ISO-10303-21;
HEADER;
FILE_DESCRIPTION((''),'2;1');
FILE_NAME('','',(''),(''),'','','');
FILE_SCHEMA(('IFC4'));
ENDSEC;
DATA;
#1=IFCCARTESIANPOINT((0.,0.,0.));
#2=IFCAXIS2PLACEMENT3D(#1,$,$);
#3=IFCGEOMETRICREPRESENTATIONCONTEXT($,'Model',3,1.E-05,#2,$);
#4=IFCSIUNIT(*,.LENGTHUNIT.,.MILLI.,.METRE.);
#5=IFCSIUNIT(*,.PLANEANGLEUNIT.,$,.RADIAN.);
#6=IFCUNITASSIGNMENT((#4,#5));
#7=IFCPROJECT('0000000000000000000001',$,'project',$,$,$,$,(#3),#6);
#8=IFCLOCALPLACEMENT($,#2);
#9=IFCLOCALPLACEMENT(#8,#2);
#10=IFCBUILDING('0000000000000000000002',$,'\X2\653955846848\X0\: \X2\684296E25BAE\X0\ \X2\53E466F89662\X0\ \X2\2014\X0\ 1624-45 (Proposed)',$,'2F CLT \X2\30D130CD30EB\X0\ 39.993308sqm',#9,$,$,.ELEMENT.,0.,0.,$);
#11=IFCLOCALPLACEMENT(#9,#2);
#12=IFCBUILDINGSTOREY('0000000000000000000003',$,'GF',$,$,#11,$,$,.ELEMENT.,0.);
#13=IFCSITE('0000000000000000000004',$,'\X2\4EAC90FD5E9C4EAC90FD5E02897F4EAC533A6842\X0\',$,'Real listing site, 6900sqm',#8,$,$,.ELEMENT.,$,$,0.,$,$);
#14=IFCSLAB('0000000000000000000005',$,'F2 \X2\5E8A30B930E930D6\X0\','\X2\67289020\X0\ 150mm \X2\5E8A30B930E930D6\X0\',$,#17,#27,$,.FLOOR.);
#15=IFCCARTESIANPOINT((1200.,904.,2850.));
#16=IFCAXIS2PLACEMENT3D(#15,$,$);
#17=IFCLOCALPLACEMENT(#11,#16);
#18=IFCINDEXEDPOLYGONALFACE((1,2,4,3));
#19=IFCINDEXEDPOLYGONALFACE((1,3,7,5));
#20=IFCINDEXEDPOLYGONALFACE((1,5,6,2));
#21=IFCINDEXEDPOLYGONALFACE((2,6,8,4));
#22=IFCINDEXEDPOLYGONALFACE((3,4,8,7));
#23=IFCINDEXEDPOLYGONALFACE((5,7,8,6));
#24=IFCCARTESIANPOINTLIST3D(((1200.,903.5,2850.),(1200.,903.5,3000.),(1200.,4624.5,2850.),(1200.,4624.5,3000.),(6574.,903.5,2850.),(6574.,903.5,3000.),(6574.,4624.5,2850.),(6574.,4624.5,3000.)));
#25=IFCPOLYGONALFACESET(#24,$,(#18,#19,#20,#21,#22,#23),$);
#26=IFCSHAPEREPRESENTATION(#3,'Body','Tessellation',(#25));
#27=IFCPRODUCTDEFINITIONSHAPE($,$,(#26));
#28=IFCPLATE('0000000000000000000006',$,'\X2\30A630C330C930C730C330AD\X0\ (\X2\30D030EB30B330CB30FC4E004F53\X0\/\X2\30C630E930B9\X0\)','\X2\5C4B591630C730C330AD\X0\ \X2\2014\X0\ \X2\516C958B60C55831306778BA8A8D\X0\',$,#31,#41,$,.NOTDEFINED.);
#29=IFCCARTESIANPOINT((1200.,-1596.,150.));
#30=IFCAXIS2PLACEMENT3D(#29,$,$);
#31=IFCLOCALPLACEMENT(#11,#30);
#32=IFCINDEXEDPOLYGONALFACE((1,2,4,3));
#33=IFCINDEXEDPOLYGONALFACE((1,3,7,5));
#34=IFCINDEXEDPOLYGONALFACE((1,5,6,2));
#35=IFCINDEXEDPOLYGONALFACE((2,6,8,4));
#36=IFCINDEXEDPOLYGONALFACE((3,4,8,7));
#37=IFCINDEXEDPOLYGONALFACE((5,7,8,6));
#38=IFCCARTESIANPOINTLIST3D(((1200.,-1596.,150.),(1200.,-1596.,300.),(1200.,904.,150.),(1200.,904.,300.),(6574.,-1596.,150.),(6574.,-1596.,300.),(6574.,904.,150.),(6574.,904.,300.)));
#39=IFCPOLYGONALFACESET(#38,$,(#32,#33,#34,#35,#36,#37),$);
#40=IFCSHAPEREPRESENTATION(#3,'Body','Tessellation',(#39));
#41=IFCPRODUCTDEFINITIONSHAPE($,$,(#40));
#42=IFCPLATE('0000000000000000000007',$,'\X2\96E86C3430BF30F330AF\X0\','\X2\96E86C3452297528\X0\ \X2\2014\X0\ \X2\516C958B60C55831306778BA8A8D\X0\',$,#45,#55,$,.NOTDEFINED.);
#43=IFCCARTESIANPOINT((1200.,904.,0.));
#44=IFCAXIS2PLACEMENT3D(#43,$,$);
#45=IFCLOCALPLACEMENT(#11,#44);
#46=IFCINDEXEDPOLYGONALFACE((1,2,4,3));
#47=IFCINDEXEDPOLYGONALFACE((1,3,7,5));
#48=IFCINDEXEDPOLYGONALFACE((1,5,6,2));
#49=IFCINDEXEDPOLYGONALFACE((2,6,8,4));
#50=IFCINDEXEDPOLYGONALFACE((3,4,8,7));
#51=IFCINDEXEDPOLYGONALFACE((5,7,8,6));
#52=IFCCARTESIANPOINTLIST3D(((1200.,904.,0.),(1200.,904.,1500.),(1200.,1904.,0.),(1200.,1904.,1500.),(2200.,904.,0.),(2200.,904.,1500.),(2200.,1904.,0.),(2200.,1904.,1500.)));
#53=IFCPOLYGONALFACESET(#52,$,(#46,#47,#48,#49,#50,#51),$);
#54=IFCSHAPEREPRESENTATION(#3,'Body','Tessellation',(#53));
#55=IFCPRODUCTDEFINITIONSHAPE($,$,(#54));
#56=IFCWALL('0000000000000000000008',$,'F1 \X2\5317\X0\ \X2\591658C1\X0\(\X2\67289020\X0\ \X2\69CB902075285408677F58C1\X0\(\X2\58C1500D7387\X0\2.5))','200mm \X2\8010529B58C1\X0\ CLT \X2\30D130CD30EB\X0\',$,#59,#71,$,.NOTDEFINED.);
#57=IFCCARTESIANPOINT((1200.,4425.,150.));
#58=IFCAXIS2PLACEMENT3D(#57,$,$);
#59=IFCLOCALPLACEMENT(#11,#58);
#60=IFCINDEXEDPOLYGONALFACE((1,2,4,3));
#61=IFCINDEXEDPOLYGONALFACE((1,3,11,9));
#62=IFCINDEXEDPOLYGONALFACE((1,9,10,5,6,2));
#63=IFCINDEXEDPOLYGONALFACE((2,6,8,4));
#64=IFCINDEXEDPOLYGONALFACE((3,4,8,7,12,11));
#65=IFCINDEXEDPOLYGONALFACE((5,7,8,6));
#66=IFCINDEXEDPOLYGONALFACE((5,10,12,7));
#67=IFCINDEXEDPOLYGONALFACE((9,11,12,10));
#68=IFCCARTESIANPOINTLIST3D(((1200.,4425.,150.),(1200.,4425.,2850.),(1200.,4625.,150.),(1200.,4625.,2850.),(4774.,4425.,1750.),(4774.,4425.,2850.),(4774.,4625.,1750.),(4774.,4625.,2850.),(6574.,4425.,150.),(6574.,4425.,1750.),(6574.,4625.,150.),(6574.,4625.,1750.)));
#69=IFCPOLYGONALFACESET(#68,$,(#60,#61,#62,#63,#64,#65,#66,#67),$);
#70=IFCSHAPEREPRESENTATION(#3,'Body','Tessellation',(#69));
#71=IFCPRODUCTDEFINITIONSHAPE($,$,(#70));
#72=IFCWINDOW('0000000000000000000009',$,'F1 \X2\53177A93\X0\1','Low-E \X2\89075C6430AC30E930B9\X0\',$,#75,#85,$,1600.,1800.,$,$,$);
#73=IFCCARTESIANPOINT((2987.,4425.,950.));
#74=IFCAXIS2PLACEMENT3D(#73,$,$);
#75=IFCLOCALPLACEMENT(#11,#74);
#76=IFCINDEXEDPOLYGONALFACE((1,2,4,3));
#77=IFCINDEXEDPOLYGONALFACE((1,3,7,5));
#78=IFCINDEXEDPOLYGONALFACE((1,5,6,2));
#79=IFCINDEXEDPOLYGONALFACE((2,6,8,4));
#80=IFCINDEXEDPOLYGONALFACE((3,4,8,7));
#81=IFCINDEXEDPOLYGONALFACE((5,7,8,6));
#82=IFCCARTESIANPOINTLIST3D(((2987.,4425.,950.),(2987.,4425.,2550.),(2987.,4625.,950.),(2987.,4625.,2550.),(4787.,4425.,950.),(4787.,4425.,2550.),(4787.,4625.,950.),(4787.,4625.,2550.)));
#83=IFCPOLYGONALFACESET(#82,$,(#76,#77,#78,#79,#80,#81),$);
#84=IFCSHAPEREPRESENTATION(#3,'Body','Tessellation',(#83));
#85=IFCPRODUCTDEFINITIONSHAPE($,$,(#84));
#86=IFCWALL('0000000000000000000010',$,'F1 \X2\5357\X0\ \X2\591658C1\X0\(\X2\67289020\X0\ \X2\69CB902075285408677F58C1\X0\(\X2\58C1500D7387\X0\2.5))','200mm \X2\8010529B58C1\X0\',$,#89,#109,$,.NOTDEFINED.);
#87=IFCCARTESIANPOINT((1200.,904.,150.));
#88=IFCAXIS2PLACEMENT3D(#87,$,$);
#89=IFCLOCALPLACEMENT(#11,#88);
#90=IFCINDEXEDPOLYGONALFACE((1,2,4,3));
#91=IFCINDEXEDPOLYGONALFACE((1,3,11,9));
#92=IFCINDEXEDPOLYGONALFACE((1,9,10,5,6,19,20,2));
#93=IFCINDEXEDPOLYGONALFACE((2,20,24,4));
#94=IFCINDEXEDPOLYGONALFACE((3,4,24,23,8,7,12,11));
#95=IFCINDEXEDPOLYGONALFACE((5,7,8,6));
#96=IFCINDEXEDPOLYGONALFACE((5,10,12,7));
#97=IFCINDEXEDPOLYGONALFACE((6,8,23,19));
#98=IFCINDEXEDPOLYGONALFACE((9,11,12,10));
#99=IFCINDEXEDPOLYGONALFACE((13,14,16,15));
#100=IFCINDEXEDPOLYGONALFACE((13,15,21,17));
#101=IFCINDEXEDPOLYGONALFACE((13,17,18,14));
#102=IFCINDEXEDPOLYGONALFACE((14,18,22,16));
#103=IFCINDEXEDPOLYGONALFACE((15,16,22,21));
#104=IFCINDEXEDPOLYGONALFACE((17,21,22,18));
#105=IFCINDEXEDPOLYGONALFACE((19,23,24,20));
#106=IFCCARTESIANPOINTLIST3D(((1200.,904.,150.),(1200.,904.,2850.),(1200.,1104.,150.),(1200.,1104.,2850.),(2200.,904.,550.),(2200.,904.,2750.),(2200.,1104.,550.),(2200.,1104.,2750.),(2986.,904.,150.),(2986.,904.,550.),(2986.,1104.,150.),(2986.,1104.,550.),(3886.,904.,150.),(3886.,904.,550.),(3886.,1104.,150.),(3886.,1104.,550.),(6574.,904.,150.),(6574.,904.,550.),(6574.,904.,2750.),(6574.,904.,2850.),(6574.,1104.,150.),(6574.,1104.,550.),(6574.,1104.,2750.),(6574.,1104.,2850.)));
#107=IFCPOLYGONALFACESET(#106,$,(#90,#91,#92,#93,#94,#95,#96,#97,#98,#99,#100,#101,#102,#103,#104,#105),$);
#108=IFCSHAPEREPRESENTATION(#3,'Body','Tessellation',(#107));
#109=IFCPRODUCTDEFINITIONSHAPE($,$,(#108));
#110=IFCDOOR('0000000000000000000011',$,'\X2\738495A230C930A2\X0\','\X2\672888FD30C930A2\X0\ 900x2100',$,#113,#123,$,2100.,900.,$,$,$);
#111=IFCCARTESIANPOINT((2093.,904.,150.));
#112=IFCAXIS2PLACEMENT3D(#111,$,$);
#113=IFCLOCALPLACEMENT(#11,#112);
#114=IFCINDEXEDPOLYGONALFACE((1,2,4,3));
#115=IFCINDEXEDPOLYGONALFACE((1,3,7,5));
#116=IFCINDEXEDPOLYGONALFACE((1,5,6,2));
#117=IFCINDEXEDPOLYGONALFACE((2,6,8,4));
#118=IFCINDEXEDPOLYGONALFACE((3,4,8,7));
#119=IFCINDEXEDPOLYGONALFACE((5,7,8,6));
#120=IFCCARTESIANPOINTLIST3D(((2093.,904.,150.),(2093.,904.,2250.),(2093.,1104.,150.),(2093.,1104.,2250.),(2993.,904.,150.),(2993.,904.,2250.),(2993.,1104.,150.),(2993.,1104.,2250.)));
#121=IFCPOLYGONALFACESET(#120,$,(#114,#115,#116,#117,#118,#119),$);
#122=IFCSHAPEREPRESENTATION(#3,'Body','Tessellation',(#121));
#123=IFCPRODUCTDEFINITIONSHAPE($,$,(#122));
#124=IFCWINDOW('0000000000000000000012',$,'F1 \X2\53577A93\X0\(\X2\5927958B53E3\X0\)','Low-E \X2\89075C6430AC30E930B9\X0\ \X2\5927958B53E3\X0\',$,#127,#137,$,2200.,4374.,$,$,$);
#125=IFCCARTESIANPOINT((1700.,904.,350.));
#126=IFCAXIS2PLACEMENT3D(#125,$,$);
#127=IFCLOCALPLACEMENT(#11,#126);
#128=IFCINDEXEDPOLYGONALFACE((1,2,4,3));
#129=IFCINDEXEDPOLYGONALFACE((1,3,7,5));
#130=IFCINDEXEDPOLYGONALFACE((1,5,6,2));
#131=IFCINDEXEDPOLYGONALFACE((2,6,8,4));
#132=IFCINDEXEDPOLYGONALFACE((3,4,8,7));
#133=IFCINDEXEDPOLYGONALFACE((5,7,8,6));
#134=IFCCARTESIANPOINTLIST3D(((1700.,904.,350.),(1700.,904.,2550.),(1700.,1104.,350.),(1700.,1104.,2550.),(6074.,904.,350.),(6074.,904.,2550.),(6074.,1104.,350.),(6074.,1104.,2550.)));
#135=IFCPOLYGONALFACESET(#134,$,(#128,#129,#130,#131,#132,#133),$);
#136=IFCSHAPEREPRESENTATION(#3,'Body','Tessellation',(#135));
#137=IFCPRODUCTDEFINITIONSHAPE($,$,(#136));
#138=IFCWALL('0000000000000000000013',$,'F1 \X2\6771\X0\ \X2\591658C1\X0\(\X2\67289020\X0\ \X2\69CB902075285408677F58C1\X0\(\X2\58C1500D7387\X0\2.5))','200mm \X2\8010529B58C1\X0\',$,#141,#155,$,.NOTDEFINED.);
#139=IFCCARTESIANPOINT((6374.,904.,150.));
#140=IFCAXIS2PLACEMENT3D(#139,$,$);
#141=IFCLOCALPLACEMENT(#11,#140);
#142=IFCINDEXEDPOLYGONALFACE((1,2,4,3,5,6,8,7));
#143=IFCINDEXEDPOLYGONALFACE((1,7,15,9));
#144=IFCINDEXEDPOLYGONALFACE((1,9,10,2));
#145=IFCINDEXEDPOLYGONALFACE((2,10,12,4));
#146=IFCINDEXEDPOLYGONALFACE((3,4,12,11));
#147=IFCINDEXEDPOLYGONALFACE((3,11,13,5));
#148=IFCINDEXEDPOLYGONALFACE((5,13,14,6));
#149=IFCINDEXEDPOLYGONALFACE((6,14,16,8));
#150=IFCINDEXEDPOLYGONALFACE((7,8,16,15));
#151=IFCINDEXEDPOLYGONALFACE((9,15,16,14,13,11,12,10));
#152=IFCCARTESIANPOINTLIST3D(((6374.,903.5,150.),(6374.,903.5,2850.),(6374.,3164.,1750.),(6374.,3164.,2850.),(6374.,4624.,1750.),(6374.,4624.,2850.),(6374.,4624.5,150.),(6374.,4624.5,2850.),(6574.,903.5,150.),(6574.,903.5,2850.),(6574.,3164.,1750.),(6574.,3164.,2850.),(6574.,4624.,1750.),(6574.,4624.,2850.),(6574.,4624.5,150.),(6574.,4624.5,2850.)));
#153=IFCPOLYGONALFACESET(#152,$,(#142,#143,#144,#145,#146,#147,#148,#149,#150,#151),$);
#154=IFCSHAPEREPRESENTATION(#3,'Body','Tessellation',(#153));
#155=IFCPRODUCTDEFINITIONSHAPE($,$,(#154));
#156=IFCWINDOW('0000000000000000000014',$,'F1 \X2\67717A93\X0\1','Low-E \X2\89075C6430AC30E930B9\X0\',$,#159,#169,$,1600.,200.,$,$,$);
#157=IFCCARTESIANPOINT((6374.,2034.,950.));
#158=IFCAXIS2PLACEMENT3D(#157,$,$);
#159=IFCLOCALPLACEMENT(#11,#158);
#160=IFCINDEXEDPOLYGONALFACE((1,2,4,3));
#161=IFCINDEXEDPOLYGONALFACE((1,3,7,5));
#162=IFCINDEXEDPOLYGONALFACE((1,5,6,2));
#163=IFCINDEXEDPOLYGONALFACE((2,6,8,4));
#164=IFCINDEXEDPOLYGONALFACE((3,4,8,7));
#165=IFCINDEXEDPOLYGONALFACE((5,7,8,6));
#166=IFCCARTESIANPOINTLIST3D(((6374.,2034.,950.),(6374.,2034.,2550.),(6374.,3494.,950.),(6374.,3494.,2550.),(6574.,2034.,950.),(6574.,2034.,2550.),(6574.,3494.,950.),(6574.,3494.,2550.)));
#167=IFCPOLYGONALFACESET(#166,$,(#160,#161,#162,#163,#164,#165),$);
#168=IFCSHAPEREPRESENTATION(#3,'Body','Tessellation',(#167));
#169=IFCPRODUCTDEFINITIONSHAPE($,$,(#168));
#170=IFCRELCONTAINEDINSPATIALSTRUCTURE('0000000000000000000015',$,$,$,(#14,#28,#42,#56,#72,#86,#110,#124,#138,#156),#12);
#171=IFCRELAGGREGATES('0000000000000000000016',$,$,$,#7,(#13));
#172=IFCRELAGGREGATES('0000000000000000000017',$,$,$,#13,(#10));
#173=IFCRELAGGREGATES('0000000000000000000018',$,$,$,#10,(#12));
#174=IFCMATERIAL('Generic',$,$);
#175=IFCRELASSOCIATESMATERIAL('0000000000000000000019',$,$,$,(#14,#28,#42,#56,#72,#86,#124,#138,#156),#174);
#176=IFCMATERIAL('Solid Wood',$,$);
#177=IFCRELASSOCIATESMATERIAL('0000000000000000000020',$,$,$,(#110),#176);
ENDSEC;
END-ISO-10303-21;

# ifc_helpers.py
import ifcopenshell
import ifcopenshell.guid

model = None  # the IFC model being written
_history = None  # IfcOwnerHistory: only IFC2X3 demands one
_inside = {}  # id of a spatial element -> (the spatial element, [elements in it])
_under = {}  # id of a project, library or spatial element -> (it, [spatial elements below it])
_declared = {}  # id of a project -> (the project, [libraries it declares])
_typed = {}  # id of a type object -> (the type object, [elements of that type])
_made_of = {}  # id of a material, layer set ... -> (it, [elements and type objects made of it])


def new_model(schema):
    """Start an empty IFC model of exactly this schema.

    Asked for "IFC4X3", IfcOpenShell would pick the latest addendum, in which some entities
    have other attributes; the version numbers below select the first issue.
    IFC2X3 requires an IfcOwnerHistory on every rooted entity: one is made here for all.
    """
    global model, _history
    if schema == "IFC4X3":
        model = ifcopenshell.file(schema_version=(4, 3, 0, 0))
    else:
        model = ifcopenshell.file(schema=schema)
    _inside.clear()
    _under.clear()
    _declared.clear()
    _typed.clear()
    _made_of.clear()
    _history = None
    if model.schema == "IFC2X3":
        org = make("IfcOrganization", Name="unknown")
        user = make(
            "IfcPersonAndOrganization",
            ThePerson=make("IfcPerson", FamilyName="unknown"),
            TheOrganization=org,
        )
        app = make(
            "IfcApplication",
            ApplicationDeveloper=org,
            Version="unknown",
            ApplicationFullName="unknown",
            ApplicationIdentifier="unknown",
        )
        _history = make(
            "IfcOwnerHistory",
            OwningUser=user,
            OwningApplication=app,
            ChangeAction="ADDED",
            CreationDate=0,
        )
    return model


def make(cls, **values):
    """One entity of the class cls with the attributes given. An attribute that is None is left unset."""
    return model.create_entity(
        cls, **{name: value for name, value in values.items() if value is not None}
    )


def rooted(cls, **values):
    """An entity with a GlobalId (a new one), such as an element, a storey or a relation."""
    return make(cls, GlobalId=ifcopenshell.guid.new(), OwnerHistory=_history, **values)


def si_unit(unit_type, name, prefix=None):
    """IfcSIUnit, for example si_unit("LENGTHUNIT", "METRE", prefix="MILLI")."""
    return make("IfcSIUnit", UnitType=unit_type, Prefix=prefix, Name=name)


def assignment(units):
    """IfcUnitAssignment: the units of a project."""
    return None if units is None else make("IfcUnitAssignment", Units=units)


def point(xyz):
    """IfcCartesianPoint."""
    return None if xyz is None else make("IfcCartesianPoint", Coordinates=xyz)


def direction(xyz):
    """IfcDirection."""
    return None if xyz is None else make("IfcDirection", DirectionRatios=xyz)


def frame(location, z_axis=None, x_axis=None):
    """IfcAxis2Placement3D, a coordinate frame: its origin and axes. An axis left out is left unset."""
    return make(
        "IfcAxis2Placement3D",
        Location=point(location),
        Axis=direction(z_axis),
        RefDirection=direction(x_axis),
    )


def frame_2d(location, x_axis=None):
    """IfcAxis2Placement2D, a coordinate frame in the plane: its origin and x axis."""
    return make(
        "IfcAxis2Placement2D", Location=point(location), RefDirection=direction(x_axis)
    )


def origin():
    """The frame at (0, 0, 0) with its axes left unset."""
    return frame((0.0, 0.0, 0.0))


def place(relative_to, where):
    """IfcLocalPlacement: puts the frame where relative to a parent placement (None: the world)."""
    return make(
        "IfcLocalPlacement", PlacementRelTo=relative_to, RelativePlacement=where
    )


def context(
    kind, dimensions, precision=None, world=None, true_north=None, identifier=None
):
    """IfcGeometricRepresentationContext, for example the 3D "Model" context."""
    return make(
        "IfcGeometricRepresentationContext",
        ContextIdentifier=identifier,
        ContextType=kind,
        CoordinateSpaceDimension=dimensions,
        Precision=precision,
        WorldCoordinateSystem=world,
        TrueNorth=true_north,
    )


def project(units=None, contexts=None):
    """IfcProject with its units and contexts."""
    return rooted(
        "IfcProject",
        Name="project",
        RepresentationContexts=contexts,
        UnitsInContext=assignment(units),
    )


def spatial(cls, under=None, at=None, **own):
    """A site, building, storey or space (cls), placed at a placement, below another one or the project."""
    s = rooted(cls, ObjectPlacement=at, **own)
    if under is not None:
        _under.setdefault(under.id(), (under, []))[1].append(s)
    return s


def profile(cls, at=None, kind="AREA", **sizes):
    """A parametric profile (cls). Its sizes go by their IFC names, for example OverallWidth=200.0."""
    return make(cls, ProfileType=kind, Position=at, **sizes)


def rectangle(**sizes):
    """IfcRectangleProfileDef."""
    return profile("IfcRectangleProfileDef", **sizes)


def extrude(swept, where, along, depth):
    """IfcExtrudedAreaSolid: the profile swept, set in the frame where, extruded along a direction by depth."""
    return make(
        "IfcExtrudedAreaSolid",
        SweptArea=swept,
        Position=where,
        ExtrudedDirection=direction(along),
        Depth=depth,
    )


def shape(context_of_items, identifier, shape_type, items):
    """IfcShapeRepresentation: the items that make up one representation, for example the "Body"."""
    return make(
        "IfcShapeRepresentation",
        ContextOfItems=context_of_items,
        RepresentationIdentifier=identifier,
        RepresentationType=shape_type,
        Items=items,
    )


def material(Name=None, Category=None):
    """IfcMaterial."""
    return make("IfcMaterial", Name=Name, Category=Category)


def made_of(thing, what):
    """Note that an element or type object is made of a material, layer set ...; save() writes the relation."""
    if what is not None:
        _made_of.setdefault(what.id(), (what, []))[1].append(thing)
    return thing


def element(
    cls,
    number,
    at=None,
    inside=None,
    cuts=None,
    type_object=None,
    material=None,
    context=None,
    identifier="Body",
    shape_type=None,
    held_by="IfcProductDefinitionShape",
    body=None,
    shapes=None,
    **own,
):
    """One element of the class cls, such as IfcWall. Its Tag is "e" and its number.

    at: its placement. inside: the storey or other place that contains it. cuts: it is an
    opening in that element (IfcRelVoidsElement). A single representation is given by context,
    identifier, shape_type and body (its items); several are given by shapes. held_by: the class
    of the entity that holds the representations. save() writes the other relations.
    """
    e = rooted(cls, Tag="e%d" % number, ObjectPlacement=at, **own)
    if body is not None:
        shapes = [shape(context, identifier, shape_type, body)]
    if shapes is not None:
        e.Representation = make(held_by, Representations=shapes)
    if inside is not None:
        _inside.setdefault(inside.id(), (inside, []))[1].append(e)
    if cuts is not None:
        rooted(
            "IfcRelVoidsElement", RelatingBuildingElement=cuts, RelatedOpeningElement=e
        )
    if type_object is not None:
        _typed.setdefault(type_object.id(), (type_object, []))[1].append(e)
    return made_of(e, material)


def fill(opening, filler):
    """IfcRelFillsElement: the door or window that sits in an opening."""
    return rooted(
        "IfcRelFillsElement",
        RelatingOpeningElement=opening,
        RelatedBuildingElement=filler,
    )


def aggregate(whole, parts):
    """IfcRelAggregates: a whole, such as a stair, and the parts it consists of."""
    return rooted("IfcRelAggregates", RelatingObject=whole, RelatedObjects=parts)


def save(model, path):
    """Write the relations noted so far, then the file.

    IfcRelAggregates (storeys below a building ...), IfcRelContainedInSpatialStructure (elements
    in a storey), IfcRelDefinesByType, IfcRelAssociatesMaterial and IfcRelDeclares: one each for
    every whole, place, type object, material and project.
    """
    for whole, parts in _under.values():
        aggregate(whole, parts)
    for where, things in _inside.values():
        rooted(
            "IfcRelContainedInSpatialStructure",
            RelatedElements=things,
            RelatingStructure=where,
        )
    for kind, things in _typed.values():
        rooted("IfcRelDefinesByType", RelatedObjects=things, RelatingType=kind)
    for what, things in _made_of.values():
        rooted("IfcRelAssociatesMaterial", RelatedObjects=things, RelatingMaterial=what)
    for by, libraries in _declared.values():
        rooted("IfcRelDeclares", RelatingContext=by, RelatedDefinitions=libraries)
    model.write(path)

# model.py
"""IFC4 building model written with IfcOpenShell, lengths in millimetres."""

from ifc_helpers import new_model, si_unit, frame, frame_2d, origin, place, context, project, spatial, rectangle, extrude, material, element, fill, save


model = new_model("IFC4")

# Units and contexts
model_context = context("Model", 3, precision=1e-05, world=origin())
ifc_project = project(units=[si_unit("LENGTHUNIT", "METRE", prefix="MILLI"), si_unit("PLANEANGLEUNIT", "RADIAN")], contexts=[model_context])

# Site, building, storey
site_placement = place(None, origin())
site = spatial("IfcSite", under=ifc_project, at=site_placement, Name="京都府京都市西京区桂", ObjectType="Real listing site, 6900sqm", CompositionType="ELEMENT", RefElevation=0.0)
building_placement = place(site_placement, origin())
building = spatial("IfcBuilding", under=site, at=building_placement, Name="改善案: 桂離宮 古書院 — 1624-45 (Proposed)", ObjectType="2F CLT パネル 39.993308sqm", CompositionType="ELEMENT", ElevationOfRefHeight=0.0, ElevationOfTerrain=0.0)
storey_placement = place(building_placement, origin())
storey = spatial("IfcBuildingStorey", under=building, at=storey_placement, Name="GF", CompositionType="ELEMENT", Elevation=0.0)

# Slab
ifc_material_1 = material(Name="Generic")
slab_1_placement = place(storey_placement, frame((1200.0, 904.0, 2850.0)))
element("IfcSlab", 1, at=slab_1_placement, inside=storey, material=ifc_material_1, Name="F2 床スラブ", Description="木造 150mm 床スラブ", PredefinedType="FLOOR", context=model_context, shape_type="SweptSolid", body=[
    extrude(rectangle(XDim=5374.0, YDim=3721.0, at=frame_2d((2687.0, 1860.0))), frame((1200.0, 904.0, 2850.0)), (0.0, 0.0, 1.0), 150.0),
])

# Plates
plate_1_placement = place(storey_placement, frame((1200.0, -1596.0, 150.0)))
element("IfcPlate", 2, at=plate_1_placement, inside=storey, material=ifc_material_1, Name="ウッドデッキ (バルコニー一体/テラス)", Description="屋外デッキ — 公開情報で確認", PredefinedType="NOTDEFINED", context=model_context, shape_type="SweptSolid", body=[
    extrude(rectangle(XDim=5374.0, YDim=2500.0, at=frame_2d((2687.0, 1250.0))), frame((1200.0, -1596.0, 150.0)), (0.0, 0.0, 1.0), 150.0),
])
plate_2_placement = place(storey_placement, frame((1200.0, 904.0, 0.0)))
element("IfcPlate", 3, at=plate_2_placement, inside=storey, material=ifc_material_1, Name="雨水タンク", Description="雨水利用 — 公開情報で確認", PredefinedType="NOTDEFINED", context=model_context, shape_type="SweptSolid", body=[
    extrude(rectangle(XDim=1000.0, YDim=1000.0, at=frame_2d((500.0, 500.0))), frame((1200.0, 904.0, 0.0)), (0.0, 0.0, 1.0), 1500.0),
])

# Wall, opening, window
wall_1_placement = place(storey_placement, frame((1200.0, 4425.0, 150.0)))
wall_1 = element("IfcWall", 4, at=wall_1_placement, inside=storey, material=ifc_material_1, Name="F1 北 外壁(木造 構造用合板壁(壁倍率2.5))", Description="200mm 耐力壁 CLT パネル", PredefinedType="NOTDEFINED", context=model_context, shape_type="SweptSolid", body=[
    extrude(rectangle(XDim=5374.0, YDim=200.0, at=frame_2d((2687.0, 100.0))), frame((1200.0, 4425.0, 150.0)), (0.0, 0.0, 1.0), 2700.0),
])
opening_1_placement = place(storey_placement, frame((2987.0, 4425.0, 950.0)))
opening_1 = element("IfcOpeningElement", 5, at=opening_1_placement, cuts=wall_1, PredefinedType="NOTDEFINED", context=model_context, shape_type="SweptSolid", body=[
    extrude(rectangle(XDim=1800.0, YDim=200.0, at=frame_2d((900.0, 100.0))), frame((2987.0, 4425.0, 950.0)), (0.0, 0.0, 1.0), 1600.0),
])
window_1_placement = place(storey_placement, frame((2987.0, 4425.0, 950.0)))
window_1 = element("IfcWindow", 6, at=window_1_placement, inside=storey, material=ifc_material_1, Name="F1 北窓1", Description="Low-E 複層ガラス", OverallHeight=1600.0, OverallWidth=1800.0, context=model_context, shape_type="SweptSolid", body=[
    extrude(rectangle(XDim=1800.0, YDim=200.0, at=frame_2d((900.0, 100.0))), frame((2987.0, 4425.0, 950.0)), (0.0, 0.0, 1.0), 1600.0),
])
fill(opening_1, window_1)

# Wall, openings, door, window
wall_2_placement = place(storey_placement, frame((1200.0, 904.0, 150.0)))
wall_2 = element("IfcWall", 7, at=wall_2_placement, inside=storey, material=ifc_material_1, Name="F1 南 外壁(木造 構造用合板壁(壁倍率2.5))", Description="200mm 耐力壁", PredefinedType="NOTDEFINED", context=model_context, shape_type="SweptSolid", body=[
    extrude(rectangle(XDim=5374.0, YDim=200.0, at=frame_2d((2687.0, 100.0))), frame((1200.0, 904.0, 150.0)), (0.0, 0.0, 1.0), 2700.0),
])
opening_2_placement = place(storey_placement, frame((2093.0, 904.0, 150.0)))
opening_2 = element("IfcOpeningElement", 8, at=opening_2_placement, cuts=wall_2, PredefinedType="NOTDEFINED", context=model_context, shape_type="SweptSolid", body=[
    extrude(rectangle(XDim=900.0, YDim=200.0, at=frame_2d((450.0, 100.0))), frame((2093.0, 904.0, 150.0)), (0.0, 0.0, 1.0), 2100.0),
])
opening_3_placement = place(storey_placement, frame((1700.0, 904.0, 350.0)))
opening_3 = element("IfcOpeningElement", 9, at=opening_3_placement, cuts=wall_2, PredefinedType="NOTDEFINED", context=model_context, shape_type="SweptSolid", body=[
    extrude(rectangle(XDim=4374.0, YDim=200.0, at=frame_2d((2187.0, 100.0))), frame((1700.0, 904.0, 350.0)), (0.0, 0.0, 1.0), 2200.0),
])
ifc_material_2 = material(Name="Solid Wood")
door_placement = place(storey_placement, frame((2093.0, 904.0, 150.0)))
door = element("IfcDoor", 10, at=door_placement, inside=storey, material=ifc_material_2, Name="玄関ドア", Description="木製ドア 900x2100", OverallHeight=2100.0, OverallWidth=900.0, context=model_context, shape_type="SweptSolid", body=[
    extrude(rectangle(XDim=900.0, YDim=200.0, at=frame_2d((450.0, 100.0))), frame((2093.0, 904.0, 150.0)), (0.0, 0.0, 1.0), 2100.0),
])
fill(opening_2, door)
window_2_placement = place(storey_placement, frame((1700.0, 904.0, 350.0)))
window_2 = element("IfcWindow", 11, at=window_2_placement, inside=storey, material=ifc_material_1, Name="F1 南窓(大開口)", Description="Low-E 複層ガラス 大開口", OverallHeight=2200.0, OverallWidth=4374.0, context=model_context, shape_type="SweptSolid", body=[
    extrude(rectangle(XDim=4374.0, YDim=200.0, at=frame_2d((2187.0, 100.0))), frame((1700.0, 904.0, 350.0)), (0.0, 0.0, 1.0), 2200.0),
])
fill(opening_3, window_2)

# Wall, opening, window
wall_3_placement = place(storey_placement, frame((6374.0, 904.0, 150.0)))
wall_3 = element("IfcWall", 12, at=wall_3_placement, inside=storey, material=ifc_material_1, Name="F1 東 外壁(木造 構造用合板壁(壁倍率2.5))", Description="200mm 耐力壁", PredefinedType="NOTDEFINED", context=model_context, shape_type="SweptSolid", body=[
    extrude(rectangle(XDim=200.0, YDim=3721.0, at=frame_2d((100.0, 1860.0))), frame((6374.0, 904.0, 150.0)), (0.0, 0.0, 1.0), 2700.0),
])
opening_4_placement = place(storey_placement, frame((6374.0, 2034.0, 950.0)))
opening_4 = element("IfcOpeningElement", 13, at=opening_4_placement, cuts=wall_3, PredefinedType="NOTDEFINED", context=model_context, shape_type="SweptSolid", body=[
    extrude(rectangle(XDim=200.0, YDim=1460.0, at=frame_2d((100.0, 730.0))), frame((6374.0, 2034.0, 950.0)), (0.0, 0.0, 1.0), 1600.0),
])
window_3_placement = place(storey_placement, frame((6374.0, 2034.0, 950.0)))
window_3 = element("IfcWindow", 14, at=window_3_placement, inside=storey, material=ifc_material_1, Name="F1 東窓1", Description="Low-E 複層ガラス", OverallHeight=1600.0, OverallWidth=200.0, context=model_context, shape_type="SweptSolid", body=[
    extrude(rectangle(XDim=200.0, YDim=1460.0, at=frame_2d((100.0, 730.0))), frame((6374.0, 2034.0, 950.0)), (0.0, 0.0, 1.0), 1600.0),
])
fill(opening_4, window_3)

save(model, "model.ifc")
